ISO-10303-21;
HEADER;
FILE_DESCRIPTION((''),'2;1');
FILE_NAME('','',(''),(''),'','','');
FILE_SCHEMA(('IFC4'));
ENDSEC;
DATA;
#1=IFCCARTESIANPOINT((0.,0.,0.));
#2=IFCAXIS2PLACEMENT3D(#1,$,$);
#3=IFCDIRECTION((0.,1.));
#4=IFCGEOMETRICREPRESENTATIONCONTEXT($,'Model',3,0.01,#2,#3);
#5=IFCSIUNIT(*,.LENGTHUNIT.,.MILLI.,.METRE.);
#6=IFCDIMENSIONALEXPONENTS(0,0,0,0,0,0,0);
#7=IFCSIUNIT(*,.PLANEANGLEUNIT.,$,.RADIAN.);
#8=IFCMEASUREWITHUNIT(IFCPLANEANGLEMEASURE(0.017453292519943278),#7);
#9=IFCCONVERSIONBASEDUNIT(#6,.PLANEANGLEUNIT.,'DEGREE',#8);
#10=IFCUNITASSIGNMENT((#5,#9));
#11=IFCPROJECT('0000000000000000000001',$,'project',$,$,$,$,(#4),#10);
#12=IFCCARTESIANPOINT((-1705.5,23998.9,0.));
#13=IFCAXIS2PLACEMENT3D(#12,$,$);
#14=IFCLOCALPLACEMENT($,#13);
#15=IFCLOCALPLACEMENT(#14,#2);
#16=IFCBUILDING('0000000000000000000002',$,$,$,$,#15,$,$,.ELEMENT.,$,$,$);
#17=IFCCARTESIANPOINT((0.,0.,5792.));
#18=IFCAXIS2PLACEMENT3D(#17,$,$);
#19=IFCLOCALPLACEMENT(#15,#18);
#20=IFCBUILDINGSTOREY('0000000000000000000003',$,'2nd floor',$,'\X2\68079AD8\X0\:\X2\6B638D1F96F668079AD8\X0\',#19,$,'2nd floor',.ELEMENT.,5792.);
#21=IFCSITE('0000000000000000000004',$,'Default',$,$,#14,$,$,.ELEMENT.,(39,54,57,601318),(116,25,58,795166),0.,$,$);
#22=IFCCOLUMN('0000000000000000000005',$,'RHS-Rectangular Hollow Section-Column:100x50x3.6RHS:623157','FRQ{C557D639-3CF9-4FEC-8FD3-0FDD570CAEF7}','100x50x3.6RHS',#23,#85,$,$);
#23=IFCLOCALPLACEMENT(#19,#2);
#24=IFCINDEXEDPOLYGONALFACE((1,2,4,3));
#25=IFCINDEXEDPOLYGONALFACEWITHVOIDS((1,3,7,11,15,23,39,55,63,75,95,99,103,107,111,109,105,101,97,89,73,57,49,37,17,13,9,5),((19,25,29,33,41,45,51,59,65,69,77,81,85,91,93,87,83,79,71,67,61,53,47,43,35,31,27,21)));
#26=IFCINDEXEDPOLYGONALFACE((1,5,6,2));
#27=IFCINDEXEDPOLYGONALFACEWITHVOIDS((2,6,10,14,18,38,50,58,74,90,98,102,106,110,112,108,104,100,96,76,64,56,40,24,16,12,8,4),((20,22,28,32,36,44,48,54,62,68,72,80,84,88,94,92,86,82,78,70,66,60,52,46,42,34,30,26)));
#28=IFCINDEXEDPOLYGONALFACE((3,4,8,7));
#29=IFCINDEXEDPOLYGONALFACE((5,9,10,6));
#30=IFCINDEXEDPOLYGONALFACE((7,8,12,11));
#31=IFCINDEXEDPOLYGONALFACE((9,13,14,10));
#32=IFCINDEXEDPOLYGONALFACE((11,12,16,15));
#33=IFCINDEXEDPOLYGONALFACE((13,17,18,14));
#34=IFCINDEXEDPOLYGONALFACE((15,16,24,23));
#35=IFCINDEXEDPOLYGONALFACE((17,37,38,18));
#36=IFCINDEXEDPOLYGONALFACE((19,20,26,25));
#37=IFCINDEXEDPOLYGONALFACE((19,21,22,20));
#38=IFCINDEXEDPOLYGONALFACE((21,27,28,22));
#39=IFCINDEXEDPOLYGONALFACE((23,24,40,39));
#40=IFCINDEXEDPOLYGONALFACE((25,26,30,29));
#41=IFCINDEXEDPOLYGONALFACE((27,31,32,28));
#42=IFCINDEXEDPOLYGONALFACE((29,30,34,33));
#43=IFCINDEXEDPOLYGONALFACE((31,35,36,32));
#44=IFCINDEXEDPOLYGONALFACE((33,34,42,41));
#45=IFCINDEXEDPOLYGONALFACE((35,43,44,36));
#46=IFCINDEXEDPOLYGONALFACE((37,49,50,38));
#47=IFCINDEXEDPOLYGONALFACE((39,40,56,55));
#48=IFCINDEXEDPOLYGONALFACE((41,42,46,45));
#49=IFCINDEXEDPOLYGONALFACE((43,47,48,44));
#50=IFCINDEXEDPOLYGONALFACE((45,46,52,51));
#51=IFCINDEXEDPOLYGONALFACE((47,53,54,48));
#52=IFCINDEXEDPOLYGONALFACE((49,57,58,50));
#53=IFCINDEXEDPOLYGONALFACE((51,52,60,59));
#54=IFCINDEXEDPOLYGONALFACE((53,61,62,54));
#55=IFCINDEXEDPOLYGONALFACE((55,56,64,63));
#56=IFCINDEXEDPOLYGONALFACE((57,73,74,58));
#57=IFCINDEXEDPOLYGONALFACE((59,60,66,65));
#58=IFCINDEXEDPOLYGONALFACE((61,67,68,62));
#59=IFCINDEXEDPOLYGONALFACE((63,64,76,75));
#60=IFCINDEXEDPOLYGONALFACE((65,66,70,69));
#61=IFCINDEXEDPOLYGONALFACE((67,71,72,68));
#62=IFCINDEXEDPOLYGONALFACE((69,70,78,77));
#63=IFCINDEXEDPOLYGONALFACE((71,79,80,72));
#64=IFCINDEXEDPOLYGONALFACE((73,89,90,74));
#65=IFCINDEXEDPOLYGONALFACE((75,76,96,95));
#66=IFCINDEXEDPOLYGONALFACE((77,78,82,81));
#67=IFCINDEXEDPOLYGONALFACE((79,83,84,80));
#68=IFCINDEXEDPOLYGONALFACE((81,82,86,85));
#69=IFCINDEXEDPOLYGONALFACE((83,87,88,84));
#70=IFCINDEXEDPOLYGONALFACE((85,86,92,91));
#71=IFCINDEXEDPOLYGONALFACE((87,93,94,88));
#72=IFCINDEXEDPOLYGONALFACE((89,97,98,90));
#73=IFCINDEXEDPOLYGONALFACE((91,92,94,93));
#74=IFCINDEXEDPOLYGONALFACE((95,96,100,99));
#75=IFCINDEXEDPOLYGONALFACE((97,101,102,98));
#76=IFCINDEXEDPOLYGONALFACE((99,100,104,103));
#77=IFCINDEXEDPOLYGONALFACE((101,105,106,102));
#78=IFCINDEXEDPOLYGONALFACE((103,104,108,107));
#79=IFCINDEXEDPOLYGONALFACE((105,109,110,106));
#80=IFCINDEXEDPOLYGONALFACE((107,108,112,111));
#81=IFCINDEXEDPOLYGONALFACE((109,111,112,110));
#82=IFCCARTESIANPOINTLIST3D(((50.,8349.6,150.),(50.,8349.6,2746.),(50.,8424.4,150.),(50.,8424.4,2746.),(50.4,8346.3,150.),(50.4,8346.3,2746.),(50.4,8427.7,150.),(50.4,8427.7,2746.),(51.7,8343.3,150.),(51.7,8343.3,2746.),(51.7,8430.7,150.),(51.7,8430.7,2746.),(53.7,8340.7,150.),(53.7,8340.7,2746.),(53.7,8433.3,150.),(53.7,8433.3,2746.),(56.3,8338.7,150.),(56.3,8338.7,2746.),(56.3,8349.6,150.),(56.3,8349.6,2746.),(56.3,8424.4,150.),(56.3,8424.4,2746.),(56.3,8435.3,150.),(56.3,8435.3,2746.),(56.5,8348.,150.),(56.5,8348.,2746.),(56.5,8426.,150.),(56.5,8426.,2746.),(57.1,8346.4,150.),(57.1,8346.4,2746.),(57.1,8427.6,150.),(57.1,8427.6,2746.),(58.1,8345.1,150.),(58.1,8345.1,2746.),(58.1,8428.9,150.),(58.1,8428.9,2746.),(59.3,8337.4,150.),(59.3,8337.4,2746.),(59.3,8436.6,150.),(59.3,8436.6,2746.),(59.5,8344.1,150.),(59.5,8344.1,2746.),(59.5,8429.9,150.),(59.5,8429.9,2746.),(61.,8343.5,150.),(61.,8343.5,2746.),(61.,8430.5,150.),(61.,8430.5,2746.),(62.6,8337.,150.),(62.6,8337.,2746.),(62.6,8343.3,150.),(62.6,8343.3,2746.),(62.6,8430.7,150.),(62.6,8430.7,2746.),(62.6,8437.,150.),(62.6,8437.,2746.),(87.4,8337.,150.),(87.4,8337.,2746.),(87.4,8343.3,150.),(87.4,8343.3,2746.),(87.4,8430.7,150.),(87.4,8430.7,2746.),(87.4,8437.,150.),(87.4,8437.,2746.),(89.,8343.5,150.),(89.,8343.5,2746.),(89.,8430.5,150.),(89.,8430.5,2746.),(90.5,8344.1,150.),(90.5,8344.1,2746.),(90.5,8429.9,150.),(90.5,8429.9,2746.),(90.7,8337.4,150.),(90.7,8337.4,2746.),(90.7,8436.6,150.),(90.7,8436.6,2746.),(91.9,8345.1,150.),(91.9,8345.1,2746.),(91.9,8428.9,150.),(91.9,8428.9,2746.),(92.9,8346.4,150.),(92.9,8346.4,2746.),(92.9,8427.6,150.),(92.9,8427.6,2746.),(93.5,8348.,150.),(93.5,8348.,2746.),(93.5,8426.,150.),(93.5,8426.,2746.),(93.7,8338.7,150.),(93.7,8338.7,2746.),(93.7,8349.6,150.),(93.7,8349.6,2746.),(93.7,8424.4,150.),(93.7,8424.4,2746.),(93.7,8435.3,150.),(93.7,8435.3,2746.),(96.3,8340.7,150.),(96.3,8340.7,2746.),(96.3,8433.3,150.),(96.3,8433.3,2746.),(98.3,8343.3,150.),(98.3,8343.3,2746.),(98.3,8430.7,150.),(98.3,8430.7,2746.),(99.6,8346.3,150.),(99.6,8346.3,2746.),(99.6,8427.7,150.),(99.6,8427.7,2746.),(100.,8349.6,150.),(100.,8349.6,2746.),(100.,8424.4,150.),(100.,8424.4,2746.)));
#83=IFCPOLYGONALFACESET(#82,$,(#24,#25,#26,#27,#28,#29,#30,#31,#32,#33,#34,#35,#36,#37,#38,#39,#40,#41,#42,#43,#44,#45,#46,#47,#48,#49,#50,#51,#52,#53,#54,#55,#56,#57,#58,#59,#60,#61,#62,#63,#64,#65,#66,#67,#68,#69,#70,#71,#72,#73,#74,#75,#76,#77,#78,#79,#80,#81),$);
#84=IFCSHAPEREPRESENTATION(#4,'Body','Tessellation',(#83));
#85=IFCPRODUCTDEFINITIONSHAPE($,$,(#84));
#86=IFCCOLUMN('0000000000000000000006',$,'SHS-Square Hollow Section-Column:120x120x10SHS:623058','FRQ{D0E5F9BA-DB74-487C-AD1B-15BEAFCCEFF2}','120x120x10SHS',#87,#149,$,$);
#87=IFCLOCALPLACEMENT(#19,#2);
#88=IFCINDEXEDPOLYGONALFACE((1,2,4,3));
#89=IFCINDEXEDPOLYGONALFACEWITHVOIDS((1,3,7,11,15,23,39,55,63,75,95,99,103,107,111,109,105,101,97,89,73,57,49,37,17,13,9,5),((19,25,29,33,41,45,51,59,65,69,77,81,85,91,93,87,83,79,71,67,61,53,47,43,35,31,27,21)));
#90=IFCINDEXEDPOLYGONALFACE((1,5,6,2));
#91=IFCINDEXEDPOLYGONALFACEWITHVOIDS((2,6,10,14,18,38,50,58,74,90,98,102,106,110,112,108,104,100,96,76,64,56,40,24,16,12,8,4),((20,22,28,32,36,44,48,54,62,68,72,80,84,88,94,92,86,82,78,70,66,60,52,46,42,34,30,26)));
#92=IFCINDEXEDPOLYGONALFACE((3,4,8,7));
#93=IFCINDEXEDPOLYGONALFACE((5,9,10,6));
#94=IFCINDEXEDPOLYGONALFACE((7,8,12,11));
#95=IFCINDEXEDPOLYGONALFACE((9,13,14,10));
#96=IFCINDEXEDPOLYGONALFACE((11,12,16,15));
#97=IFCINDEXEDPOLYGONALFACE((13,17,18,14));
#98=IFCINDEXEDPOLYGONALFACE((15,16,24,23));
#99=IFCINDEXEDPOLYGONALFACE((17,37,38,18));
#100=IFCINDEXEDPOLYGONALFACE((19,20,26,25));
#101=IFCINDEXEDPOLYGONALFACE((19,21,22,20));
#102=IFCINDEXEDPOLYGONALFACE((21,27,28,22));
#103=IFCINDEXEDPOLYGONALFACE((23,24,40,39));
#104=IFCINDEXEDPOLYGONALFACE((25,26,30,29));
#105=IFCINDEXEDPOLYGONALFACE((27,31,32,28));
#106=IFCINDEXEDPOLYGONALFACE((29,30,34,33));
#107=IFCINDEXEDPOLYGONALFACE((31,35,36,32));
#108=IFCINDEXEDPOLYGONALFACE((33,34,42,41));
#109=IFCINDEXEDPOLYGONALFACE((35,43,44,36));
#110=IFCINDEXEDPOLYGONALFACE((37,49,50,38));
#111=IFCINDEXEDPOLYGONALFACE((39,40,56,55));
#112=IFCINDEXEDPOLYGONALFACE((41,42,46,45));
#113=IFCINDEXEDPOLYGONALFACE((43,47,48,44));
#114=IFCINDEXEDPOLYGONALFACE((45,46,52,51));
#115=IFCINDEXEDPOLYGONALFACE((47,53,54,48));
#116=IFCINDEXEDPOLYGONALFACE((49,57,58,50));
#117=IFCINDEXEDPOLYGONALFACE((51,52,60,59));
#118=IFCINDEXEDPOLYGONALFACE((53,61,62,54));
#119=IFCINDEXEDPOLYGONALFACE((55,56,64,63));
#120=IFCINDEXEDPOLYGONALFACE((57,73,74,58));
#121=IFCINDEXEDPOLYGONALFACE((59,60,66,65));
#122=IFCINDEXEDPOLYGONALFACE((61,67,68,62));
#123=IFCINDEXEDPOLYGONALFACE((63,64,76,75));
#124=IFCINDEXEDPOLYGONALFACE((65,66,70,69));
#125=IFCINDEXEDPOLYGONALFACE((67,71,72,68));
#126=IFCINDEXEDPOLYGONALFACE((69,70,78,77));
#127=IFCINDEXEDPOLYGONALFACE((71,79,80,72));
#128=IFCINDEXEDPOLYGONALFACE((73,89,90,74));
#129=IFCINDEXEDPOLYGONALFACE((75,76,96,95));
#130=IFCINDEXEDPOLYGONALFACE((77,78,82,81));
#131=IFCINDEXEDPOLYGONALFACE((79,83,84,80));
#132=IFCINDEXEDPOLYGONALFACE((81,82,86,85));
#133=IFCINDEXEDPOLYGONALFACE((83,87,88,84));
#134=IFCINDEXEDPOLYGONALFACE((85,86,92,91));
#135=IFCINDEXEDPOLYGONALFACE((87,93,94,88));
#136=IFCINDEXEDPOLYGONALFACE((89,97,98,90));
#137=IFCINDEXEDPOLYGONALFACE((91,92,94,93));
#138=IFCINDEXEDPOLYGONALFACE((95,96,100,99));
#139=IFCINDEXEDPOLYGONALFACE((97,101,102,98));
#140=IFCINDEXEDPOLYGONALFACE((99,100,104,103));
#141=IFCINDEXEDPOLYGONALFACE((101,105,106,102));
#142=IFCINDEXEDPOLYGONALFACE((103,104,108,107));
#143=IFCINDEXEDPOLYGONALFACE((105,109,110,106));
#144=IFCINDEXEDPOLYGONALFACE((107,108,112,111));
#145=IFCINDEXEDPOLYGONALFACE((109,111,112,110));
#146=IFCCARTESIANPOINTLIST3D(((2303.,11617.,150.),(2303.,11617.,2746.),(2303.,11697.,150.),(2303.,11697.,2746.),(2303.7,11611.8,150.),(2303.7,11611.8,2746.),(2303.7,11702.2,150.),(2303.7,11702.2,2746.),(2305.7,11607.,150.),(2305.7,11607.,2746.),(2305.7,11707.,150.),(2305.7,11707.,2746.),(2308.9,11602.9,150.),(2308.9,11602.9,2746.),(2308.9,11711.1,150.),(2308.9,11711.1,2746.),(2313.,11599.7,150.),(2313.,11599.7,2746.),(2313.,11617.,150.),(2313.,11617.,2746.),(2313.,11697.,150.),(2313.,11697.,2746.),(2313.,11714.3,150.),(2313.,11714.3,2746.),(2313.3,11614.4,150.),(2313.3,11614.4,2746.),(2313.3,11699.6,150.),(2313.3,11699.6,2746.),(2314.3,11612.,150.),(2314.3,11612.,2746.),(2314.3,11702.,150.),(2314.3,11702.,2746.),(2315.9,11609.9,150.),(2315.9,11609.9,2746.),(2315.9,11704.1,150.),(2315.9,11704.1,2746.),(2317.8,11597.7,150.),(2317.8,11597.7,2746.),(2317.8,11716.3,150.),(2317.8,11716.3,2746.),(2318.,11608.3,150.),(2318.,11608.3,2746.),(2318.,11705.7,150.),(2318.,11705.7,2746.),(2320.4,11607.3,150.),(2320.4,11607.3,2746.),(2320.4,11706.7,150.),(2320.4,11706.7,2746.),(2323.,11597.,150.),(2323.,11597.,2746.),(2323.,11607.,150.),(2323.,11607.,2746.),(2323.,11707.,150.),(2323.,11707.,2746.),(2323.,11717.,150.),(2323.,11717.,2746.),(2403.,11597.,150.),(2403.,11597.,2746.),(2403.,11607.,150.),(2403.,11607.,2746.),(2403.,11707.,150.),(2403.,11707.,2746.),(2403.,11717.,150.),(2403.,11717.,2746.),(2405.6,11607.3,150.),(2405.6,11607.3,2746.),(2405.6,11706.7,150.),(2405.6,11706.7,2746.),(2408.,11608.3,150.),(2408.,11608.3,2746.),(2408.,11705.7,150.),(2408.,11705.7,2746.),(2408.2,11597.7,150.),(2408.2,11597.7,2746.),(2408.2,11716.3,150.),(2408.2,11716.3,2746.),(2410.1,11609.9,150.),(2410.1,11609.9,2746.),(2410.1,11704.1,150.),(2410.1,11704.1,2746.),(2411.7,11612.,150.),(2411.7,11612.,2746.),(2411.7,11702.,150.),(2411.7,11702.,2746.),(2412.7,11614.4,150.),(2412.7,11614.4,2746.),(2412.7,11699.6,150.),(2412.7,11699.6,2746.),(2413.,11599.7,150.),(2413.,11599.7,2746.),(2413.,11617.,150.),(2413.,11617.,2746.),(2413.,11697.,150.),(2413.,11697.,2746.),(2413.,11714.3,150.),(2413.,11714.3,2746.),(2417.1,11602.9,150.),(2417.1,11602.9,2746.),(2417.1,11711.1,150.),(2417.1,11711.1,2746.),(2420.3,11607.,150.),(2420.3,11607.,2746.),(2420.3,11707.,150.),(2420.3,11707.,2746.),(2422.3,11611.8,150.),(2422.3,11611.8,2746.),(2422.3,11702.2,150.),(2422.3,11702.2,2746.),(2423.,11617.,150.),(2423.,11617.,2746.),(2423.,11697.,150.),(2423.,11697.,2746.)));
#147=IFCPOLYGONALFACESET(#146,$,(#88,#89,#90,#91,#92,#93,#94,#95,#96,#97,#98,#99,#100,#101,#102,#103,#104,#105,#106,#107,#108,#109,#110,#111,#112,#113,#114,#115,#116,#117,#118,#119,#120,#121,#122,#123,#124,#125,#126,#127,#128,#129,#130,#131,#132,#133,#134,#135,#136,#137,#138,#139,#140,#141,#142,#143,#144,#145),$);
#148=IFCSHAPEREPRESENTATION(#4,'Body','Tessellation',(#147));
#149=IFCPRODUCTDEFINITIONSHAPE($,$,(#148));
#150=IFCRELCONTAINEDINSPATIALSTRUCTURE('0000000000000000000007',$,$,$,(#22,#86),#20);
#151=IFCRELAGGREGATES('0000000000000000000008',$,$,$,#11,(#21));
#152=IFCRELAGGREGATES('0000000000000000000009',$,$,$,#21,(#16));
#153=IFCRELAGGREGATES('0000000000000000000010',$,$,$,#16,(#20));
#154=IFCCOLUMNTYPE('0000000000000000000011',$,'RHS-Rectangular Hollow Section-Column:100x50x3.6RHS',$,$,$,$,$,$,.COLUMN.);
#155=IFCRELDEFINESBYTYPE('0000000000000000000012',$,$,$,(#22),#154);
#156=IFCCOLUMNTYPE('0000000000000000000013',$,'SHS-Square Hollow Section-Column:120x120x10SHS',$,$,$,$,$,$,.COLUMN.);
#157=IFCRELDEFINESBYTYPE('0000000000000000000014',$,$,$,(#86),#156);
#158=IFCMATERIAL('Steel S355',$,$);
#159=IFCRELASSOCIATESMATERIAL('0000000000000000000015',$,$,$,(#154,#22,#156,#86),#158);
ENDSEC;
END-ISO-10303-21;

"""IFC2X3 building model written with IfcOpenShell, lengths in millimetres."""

from ifc_helpers import new_model, entity, si_unit, converted_unit, direction, frame, origin, origin_2d, place, context, project, spatial, hollow_rectangle, extrude, clip, halfspace, material, type_object, element, save


model = new_model("IFC2X3")

# Units and contexts
model_context = context("Model", 3, precision=0.01, world=origin(), true_north=direction((0.0, 1.0)))
ifc_project = project(units=[si_unit("LENGTHUNIT", "METRE", prefix="MILLI"), converted_unit("PLANEANGLEUNIT", "DEGREE", entity("IfcPlaneAngleMeasure", 0.017453292519943278), si_unit("PLANEANGLEUNIT", "RADIAN"), dimensions=[0, 0, 0, 0, 0, 0, 0])], contexts=[model_context])

# Site, building, storey
site_placement = place(None, frame((-1705.5, 23998.9, 0.0)))
site = spatial("IfcSite", under=ifc_project, at=site_placement, Name="Default", CompositionType="ELEMENT", RefLatitude=(39, 54, 57, 601318), RefLongitude=(116, 25, 58, 795166), RefElevation=0.0)
building_placement = place(site_placement, origin())
building = spatial("IfcBuilding", under=site, at=building_placement, CompositionType="ELEMENT")
storey_placement = place(building_placement, frame((0.0, 0.0, 5792.0)))
storey = spatial("IfcBuildingStorey", under=building, at=storey_placement, Name="2nd floor", ObjectType="标高:正负零标高", LongName="2nd floor", CompositionType="ELEMENT", Elevation=5792.0)

# Shared definitions
ifc_material_1 = material(Name="Steel S355")

# Columns
column_type_1 = type_object("IfcColumnType", Name="RHS-Rectangular Hollow Section-Column:100x50x3.6RHS", PredefinedType="COLUMN", material=ifc_material_1)
column_1_placement = place(storey_placement, frame((75.0, 8387.0, 2746.0), z_axis=(0.0, 0.0, 1.0), x_axis=(-1.0, 0.0, 0.0)))
element("IfcColumn", 1, at=column_1_placement, inside=storey, type_object=column_type_1, material=ifc_material_1, Name="RHS-Rectangular Hollow Section-Column:100x50x3.6RHS:623157", Description="FRQ{C557D639-3CF9-4FEC-8FD3-0FDD570CAEF7}", ObjectType="100x50x3.6RHS", context=model_context, shape_type="Clipping", body=[
    clip(extrude(hollow_rectangle(XDim=50.0, YDim=100.0, WallThickness=6.3, InnerFilletRadius=6.3, OuterFilletRadius=12.6, at=origin_2d()), origin(), (0.0, 0.0, -1.0), 2651.9), halfspace(frame((75.0, 8387.0, -2596.0), z_axis=(0.0, 0.0, 1.0), x_axis=(-1.0, 0.0, 0.0)), True)),
])
column_type_2 = type_object("IfcColumnType", Name="SHS-Square Hollow Section-Column:120x120x10SHS", PredefinedType="COLUMN", material=ifc_material_1)
column_2_placement = place(storey_placement, frame((2363.0, 11657.0, 2830.9), z_axis=(0.0, 0.0, 1.0), x_axis=(0.0, -1.0, 0.0)))
element("IfcColumn", 2, at=column_2_placement, inside=storey, type_object=column_type_2, material=ifc_material_1, Name="SHS-Square Hollow Section-Column:120x120x10SHS:623058", Description="FRQ{D0E5F9BA-DB74-487C-AD1B-15BEAFCCEFF2}", ObjectType="120x120x10SHS", context=model_context, shape_type="Clipping", body=[
    clip(clip(extrude(hollow_rectangle(XDim=120.0, YDim=120.0, WallThickness=10.0, InnerFilletRadius=10.0, OuterFilletRadius=20.0, at=origin_2d()), origin(), (0.0, 0.0, -1.0), 2765.7), halfspace(frame((11657.0, -2363.0, -84.9), z_axis=(0.0, 0.0, -1.0), x_axis=(0.0, -1.0, 0.0)), True)), halfspace(frame((11657.0, -2363.0, -2680.9), z_axis=(0.0, 0.0, 1.0), x_axis=(0.0, 1.0, 0.0)), True)),
])

save(model, "model.ifc")
